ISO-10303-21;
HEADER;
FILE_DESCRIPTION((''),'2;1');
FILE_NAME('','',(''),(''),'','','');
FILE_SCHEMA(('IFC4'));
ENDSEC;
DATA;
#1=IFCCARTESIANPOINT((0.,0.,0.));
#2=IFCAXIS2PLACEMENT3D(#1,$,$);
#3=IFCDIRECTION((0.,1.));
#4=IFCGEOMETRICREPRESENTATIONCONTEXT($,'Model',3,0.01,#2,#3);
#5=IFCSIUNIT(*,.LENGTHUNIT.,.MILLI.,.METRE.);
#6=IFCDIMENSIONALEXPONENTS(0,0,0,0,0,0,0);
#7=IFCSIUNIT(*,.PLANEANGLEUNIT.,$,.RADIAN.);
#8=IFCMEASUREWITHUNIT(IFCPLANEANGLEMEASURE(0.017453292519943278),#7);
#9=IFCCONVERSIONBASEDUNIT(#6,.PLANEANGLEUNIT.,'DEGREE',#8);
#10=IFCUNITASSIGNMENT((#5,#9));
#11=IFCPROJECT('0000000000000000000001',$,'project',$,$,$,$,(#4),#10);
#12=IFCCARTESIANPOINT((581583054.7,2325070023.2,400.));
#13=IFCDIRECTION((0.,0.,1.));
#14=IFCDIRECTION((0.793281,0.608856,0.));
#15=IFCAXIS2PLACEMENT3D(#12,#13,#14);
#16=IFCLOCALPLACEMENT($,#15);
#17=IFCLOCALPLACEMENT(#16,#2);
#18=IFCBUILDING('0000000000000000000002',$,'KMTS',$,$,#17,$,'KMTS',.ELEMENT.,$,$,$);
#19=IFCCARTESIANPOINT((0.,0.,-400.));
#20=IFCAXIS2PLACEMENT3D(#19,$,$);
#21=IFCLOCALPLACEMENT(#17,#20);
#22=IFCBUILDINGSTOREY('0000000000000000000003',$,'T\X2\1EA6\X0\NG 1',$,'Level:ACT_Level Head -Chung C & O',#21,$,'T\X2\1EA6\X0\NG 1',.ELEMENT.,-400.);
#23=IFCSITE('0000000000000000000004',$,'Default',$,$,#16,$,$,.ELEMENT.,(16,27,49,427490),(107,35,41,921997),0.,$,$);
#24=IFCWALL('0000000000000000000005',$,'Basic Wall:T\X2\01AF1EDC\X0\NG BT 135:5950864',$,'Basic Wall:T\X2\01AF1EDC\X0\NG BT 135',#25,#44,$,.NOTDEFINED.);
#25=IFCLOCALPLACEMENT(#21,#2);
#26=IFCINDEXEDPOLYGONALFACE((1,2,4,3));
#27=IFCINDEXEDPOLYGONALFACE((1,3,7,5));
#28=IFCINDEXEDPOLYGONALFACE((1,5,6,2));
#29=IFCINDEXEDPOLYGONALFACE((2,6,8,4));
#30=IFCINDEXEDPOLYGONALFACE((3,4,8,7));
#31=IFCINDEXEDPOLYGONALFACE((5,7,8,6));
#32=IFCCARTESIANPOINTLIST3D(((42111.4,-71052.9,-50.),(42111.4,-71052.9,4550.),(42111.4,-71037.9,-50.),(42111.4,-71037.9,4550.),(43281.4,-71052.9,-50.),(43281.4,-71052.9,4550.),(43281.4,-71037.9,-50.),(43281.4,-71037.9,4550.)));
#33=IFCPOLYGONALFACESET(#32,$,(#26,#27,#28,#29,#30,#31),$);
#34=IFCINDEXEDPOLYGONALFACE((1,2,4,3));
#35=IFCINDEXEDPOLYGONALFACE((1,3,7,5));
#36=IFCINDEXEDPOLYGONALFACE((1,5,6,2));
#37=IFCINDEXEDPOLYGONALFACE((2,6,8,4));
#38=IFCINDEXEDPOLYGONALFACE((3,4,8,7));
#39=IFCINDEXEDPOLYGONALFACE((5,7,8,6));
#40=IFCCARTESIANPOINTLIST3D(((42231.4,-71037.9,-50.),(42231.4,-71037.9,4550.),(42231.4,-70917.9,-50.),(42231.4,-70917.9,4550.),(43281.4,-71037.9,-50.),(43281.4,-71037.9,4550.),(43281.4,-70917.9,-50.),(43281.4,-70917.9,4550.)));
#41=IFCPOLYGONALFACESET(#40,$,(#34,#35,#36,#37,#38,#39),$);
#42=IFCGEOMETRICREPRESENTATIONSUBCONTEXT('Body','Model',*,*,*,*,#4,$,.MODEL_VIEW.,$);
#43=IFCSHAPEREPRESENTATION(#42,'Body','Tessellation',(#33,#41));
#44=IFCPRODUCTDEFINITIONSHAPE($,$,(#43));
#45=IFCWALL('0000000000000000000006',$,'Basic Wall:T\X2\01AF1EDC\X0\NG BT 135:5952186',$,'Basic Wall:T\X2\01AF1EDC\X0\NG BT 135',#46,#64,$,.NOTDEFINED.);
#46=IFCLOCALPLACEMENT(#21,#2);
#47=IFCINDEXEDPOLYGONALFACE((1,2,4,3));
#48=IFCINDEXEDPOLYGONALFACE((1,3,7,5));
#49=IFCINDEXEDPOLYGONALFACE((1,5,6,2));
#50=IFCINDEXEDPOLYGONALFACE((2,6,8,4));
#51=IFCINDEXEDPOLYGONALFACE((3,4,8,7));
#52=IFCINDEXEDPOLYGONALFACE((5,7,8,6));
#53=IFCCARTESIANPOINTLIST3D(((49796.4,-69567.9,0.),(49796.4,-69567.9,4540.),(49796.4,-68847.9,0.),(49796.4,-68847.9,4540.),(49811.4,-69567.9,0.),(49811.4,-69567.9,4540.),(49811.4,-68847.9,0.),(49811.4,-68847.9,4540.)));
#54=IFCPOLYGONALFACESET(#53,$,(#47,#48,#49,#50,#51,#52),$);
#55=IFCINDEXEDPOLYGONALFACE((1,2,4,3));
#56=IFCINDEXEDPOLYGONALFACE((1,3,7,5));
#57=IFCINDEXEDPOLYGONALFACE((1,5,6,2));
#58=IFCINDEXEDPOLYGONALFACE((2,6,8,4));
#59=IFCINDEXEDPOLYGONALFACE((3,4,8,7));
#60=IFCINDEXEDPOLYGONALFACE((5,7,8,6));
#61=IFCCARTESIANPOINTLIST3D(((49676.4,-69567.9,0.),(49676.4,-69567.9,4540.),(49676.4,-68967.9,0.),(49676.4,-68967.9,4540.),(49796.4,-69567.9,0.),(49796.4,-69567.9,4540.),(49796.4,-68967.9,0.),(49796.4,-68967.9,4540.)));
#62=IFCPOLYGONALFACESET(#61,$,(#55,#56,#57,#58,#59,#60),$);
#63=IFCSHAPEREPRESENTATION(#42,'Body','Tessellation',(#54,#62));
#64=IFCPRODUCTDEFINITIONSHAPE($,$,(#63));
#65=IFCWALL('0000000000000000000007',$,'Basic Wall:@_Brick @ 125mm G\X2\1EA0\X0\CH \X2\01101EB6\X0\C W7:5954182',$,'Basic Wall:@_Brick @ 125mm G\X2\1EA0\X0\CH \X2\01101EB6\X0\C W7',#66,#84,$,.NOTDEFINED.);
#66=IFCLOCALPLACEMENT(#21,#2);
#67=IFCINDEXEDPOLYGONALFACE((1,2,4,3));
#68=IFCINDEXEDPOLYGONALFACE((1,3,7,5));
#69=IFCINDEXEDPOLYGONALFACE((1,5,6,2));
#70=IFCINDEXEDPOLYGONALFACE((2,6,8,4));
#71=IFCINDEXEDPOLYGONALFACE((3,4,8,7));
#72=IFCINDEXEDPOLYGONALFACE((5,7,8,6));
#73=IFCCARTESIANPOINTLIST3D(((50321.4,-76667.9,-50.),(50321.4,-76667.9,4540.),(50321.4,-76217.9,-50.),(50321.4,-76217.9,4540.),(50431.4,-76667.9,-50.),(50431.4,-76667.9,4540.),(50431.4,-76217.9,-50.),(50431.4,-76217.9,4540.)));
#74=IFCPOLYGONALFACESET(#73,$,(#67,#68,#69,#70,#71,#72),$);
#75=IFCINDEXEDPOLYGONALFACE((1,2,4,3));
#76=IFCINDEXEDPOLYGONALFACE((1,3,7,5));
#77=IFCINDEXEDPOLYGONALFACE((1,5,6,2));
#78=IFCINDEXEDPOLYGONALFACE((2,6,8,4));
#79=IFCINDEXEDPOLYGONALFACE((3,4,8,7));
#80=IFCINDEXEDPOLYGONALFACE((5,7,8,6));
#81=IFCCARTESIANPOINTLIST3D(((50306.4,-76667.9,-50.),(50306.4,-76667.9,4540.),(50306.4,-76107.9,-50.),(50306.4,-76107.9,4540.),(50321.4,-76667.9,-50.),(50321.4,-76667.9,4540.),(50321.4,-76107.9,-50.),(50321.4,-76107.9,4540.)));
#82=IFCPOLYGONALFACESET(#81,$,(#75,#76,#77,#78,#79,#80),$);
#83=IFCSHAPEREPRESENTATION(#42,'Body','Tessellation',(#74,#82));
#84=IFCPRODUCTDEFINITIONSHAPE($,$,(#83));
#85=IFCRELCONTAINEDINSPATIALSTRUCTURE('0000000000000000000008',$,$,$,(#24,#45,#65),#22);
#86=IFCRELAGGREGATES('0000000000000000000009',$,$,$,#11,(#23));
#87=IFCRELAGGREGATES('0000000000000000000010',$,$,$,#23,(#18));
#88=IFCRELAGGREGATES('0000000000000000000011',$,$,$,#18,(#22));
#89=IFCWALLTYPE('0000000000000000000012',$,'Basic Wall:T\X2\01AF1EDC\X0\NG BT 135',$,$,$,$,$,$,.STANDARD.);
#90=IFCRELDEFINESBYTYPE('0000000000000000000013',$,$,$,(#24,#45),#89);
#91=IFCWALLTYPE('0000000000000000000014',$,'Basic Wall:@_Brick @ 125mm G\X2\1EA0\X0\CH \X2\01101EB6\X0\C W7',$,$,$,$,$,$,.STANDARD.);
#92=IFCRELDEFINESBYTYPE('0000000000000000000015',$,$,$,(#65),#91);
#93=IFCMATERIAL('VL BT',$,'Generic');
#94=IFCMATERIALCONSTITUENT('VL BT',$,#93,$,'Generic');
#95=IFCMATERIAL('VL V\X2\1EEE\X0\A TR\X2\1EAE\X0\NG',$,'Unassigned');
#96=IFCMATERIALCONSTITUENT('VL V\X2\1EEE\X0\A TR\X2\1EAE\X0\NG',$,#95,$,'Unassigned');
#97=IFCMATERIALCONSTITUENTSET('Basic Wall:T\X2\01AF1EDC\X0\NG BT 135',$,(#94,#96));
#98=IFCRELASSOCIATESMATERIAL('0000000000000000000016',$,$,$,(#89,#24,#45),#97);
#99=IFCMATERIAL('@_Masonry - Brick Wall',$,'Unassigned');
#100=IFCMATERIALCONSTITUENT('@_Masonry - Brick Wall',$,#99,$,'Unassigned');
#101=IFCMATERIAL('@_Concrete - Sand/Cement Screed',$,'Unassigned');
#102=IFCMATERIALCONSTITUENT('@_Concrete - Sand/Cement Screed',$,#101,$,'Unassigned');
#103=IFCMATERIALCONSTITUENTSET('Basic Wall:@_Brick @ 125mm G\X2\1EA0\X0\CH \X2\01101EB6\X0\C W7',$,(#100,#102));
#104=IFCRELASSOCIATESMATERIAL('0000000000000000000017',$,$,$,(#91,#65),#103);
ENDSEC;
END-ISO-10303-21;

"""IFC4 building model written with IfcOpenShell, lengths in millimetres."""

from ifc_helpers import new_model, entity, si_unit, converted_unit, direction, frame, origin, place, context, subcontext, project, spatial, indexed_curve, outline, extrude, material, constituent, constituent_set, type_object, element, save


model = new_model("IFC4")

# Units and contexts
model_context = context("Model", 3, precision=0.01, world=origin(), true_north=direction((0.0, 1.0)))
body_context = subcontext(model_context, "Body", "Model", "MODEL_VIEW")
ifc_project = project(units=[si_unit("LENGTHUNIT", "METRE", prefix="MILLI"), converted_unit("PLANEANGLEUNIT", "DEGREE", entity("IfcPlaneAngleMeasure", 0.017453292519943278), si_unit("PLANEANGLEUNIT", "RADIAN"), dimensions=[0, 0, 0, 0, 0, 0, 0])], contexts=[model_context])

# Site, building, storey
site_placement = place(None, frame((581583054.7, 2325070023.2, 400.0), z_axis=(0.0, 0.0, 1.0), x_axis=(0.793281, 0.608856, 0.0)))
site = spatial("IfcSite", under=ifc_project, at=site_placement, Name="Default", CompositionType="ELEMENT", RefLatitude=(16, 27, 49, 427490), RefLongitude=(107, 35, 41, 921997), RefElevation=0.0)
building_placement = place(site_placement, origin())
building = spatial("IfcBuilding", under=site, at=building_placement, Name="KMTS", LongName="KMTS", CompositionType="ELEMENT")
storey_placement = place(building_placement, frame((0.0, 0.0, -400.0)))
storey = spatial("IfcBuildingStorey", under=building, at=storey_placement, Name="TẦNG 1", ObjectType="Level:ACT_Level Head -Chung C & O", LongName="TẦNG 1", CompositionType="ELEMENT", Elevation=-400.0)

# Shared definitions
ifc_material_1 = material(Name="VL VỮA TRẮNG", Category="Unassigned")
ifc_material_2 = material(Name="VL BT", Category="Generic")

# Walls
ifc_constituent_1 = constituent(ifc_material_2, Name="VL BT", Category="Generic")
ifc_constituent_2 = constituent(ifc_material_1, Name="VL VỮA TRẮNG", Category="Unassigned")
ifc_constituent_set_1 = constituent_set(constituents=[ifc_constituent_1, ifc_constituent_2], Name="Basic Wall:TƯỜNG BT 135")
wall_type_1 = type_object("IfcWallType", Name="Basic Wall:TƯỜNG BT 135", PredefinedType="STANDARD", material=ifc_constituent_set_1)
wall_1_placement = place(storey_placement, frame((42231.4, -70985.4, -50.0)))
element("IfcWall", 1, at=wall_1_placement, inside=storey, type_object=wall_type_1, material=ifc_constituent_set_1, Name="Basic Wall:TƯỜNG BT 135:5950864", ObjectType="Basic Wall:TƯỜNG BT 135", PredefinedType="NOTDEFINED", context=body_context, shape_type="SweptSolid", body=[
    extrude(outline(indexed_curve([(-7.5, -585.0), (7.5, -585.0), (7.5, 585.0), (-7.5, 585.0), (-7.5, -585.0)], self_intersect=False)), frame((465.0, -60.0, 0.0), z_axis=(0.0, 0.0, 1.0), x_axis=(0.0, 1.0, 0.0)), (0.0, 0.0, 1.0), 4600.0),
    extrude(outline(indexed_curve([(-60.0, -525.0), (60.0, -525.0), (60.0, 525.0), (-60.0, 525.0), (-60.0, -525.0)], self_intersect=False)), frame((525.0, 7.5, 0.0), z_axis=(0.0, 0.0, 1.0), x_axis=(0.0, -1.0, 0.0)), (0.0, 0.0, 1.0), 4600.0),
])
wall_2_placement = place(storey_placement, frame((49743.9, -68967.9, 0.0), z_axis=(0.0, 0.0, 1.0), x_axis=(0.0, -1.0, 0.0)))
element("IfcWall", 2, at=wall_2_placement, inside=storey, type_object=wall_type_1, material=ifc_constituent_set_1, Name="Basic Wall:TƯỜNG BT 135:5952186", ObjectType="Basic Wall:TƯỜNG BT 135", PredefinedType="NOTDEFINED", context=body_context, shape_type="SweptSolid", body=[
    extrude(outline(indexed_curve([(-7.5, -360.0), (7.5, -360.0), (7.5, 360.0), (-7.5, 360.0), (-7.5, -360.0)], self_intersect=False)), frame((240.0, 60.0, 0.0), z_axis=(0.0, 0.0, 1.0), x_axis=(0.0, -1.0, 0.0)), (0.0, 0.0, 1.0), 4540.0),
    extrude(outline(indexed_curve([(-60.0, -300.0), (60.0, -300.0), (60.0, 300.0), (-60.0, 300.0), (-60.0, -300.0)], self_intersect=False)), frame((300.0, -7.5, 0.0), z_axis=(0.0, 0.0, 1.0), x_axis=(0.0, 1.0, 0.0)), (0.0, 0.0, 1.0), 4540.0),
])
ifc_material_3 = material(Name="@_Masonry - Brick Wall", Category="Unassigned")
ifc_constituent_3 = constituent(ifc_material_3, Name="@_Masonry - Brick Wall", Category="Unassigned")
ifc_material_4 = material(Name="@_Concrete - Sand/Cement Screed", Category="Unassigned")
ifc_constituent_4 = constituent(ifc_material_4, Name="@_Concrete - Sand/Cement Screed", Category="Unassigned")
ifc_constituent_set_2 = constituent_set(constituents=[ifc_constituent_3, ifc_constituent_4], Name="Basic Wall:@_Brick @ 125mm GẠCH ĐẶC W7")
wall_type_2 = type_object("IfcWallType", Name="Basic Wall:@_Brick @ 125mm GẠCH ĐẶC W7", PredefinedType="STANDARD", material=ifc_constituent_set_2)
wall_3_placement = place(storey_placement, frame((50368.9, -76217.9, -50.0), z_axis=(0.0, 0.0, 1.0), x_axis=(0.0, -1.0, 0.0)))
element("IfcWall", 3, at=wall_3_placement, inside=storey, type_object=wall_type_2, material=ifc_constituent_set_2, Name="Basic Wall:@_Brick @ 125mm GẠCH ĐẶC W7:5954182", ObjectType="Basic Wall:@_Brick @ 125mm GẠCH ĐẶC W7", PredefinedType="NOTDEFINED", context=body_context, shape_type="SweptSolid", body=[
    extrude(outline(indexed_curve([(-55.0, -225.0), (55.0, -225.0), (55.0, 225.0), (-55.0, 225.0), (-55.0, -225.0)], self_intersect=False)), frame((225.0, 7.5, 0.0), z_axis=(0.0, 0.0, 1.0), x_axis=(0.0, -1.0, 0.0)), (0.0, 0.0, 1.0), 4590.0),
    extrude(outline(indexed_curve([(-7.5, -280.0), (7.5, -280.0), (7.5, 280.0), (-7.5, 280.0), (-7.5, -280.0)], self_intersect=False)), frame((170.0, -55.0, 0.0), z_axis=(0.0, 0.0, 1.0), x_axis=(0.0, 1.0, 0.0)), (0.0, 0.0, 1.0), 4590.0),
])

save(model, "model.ifc")
